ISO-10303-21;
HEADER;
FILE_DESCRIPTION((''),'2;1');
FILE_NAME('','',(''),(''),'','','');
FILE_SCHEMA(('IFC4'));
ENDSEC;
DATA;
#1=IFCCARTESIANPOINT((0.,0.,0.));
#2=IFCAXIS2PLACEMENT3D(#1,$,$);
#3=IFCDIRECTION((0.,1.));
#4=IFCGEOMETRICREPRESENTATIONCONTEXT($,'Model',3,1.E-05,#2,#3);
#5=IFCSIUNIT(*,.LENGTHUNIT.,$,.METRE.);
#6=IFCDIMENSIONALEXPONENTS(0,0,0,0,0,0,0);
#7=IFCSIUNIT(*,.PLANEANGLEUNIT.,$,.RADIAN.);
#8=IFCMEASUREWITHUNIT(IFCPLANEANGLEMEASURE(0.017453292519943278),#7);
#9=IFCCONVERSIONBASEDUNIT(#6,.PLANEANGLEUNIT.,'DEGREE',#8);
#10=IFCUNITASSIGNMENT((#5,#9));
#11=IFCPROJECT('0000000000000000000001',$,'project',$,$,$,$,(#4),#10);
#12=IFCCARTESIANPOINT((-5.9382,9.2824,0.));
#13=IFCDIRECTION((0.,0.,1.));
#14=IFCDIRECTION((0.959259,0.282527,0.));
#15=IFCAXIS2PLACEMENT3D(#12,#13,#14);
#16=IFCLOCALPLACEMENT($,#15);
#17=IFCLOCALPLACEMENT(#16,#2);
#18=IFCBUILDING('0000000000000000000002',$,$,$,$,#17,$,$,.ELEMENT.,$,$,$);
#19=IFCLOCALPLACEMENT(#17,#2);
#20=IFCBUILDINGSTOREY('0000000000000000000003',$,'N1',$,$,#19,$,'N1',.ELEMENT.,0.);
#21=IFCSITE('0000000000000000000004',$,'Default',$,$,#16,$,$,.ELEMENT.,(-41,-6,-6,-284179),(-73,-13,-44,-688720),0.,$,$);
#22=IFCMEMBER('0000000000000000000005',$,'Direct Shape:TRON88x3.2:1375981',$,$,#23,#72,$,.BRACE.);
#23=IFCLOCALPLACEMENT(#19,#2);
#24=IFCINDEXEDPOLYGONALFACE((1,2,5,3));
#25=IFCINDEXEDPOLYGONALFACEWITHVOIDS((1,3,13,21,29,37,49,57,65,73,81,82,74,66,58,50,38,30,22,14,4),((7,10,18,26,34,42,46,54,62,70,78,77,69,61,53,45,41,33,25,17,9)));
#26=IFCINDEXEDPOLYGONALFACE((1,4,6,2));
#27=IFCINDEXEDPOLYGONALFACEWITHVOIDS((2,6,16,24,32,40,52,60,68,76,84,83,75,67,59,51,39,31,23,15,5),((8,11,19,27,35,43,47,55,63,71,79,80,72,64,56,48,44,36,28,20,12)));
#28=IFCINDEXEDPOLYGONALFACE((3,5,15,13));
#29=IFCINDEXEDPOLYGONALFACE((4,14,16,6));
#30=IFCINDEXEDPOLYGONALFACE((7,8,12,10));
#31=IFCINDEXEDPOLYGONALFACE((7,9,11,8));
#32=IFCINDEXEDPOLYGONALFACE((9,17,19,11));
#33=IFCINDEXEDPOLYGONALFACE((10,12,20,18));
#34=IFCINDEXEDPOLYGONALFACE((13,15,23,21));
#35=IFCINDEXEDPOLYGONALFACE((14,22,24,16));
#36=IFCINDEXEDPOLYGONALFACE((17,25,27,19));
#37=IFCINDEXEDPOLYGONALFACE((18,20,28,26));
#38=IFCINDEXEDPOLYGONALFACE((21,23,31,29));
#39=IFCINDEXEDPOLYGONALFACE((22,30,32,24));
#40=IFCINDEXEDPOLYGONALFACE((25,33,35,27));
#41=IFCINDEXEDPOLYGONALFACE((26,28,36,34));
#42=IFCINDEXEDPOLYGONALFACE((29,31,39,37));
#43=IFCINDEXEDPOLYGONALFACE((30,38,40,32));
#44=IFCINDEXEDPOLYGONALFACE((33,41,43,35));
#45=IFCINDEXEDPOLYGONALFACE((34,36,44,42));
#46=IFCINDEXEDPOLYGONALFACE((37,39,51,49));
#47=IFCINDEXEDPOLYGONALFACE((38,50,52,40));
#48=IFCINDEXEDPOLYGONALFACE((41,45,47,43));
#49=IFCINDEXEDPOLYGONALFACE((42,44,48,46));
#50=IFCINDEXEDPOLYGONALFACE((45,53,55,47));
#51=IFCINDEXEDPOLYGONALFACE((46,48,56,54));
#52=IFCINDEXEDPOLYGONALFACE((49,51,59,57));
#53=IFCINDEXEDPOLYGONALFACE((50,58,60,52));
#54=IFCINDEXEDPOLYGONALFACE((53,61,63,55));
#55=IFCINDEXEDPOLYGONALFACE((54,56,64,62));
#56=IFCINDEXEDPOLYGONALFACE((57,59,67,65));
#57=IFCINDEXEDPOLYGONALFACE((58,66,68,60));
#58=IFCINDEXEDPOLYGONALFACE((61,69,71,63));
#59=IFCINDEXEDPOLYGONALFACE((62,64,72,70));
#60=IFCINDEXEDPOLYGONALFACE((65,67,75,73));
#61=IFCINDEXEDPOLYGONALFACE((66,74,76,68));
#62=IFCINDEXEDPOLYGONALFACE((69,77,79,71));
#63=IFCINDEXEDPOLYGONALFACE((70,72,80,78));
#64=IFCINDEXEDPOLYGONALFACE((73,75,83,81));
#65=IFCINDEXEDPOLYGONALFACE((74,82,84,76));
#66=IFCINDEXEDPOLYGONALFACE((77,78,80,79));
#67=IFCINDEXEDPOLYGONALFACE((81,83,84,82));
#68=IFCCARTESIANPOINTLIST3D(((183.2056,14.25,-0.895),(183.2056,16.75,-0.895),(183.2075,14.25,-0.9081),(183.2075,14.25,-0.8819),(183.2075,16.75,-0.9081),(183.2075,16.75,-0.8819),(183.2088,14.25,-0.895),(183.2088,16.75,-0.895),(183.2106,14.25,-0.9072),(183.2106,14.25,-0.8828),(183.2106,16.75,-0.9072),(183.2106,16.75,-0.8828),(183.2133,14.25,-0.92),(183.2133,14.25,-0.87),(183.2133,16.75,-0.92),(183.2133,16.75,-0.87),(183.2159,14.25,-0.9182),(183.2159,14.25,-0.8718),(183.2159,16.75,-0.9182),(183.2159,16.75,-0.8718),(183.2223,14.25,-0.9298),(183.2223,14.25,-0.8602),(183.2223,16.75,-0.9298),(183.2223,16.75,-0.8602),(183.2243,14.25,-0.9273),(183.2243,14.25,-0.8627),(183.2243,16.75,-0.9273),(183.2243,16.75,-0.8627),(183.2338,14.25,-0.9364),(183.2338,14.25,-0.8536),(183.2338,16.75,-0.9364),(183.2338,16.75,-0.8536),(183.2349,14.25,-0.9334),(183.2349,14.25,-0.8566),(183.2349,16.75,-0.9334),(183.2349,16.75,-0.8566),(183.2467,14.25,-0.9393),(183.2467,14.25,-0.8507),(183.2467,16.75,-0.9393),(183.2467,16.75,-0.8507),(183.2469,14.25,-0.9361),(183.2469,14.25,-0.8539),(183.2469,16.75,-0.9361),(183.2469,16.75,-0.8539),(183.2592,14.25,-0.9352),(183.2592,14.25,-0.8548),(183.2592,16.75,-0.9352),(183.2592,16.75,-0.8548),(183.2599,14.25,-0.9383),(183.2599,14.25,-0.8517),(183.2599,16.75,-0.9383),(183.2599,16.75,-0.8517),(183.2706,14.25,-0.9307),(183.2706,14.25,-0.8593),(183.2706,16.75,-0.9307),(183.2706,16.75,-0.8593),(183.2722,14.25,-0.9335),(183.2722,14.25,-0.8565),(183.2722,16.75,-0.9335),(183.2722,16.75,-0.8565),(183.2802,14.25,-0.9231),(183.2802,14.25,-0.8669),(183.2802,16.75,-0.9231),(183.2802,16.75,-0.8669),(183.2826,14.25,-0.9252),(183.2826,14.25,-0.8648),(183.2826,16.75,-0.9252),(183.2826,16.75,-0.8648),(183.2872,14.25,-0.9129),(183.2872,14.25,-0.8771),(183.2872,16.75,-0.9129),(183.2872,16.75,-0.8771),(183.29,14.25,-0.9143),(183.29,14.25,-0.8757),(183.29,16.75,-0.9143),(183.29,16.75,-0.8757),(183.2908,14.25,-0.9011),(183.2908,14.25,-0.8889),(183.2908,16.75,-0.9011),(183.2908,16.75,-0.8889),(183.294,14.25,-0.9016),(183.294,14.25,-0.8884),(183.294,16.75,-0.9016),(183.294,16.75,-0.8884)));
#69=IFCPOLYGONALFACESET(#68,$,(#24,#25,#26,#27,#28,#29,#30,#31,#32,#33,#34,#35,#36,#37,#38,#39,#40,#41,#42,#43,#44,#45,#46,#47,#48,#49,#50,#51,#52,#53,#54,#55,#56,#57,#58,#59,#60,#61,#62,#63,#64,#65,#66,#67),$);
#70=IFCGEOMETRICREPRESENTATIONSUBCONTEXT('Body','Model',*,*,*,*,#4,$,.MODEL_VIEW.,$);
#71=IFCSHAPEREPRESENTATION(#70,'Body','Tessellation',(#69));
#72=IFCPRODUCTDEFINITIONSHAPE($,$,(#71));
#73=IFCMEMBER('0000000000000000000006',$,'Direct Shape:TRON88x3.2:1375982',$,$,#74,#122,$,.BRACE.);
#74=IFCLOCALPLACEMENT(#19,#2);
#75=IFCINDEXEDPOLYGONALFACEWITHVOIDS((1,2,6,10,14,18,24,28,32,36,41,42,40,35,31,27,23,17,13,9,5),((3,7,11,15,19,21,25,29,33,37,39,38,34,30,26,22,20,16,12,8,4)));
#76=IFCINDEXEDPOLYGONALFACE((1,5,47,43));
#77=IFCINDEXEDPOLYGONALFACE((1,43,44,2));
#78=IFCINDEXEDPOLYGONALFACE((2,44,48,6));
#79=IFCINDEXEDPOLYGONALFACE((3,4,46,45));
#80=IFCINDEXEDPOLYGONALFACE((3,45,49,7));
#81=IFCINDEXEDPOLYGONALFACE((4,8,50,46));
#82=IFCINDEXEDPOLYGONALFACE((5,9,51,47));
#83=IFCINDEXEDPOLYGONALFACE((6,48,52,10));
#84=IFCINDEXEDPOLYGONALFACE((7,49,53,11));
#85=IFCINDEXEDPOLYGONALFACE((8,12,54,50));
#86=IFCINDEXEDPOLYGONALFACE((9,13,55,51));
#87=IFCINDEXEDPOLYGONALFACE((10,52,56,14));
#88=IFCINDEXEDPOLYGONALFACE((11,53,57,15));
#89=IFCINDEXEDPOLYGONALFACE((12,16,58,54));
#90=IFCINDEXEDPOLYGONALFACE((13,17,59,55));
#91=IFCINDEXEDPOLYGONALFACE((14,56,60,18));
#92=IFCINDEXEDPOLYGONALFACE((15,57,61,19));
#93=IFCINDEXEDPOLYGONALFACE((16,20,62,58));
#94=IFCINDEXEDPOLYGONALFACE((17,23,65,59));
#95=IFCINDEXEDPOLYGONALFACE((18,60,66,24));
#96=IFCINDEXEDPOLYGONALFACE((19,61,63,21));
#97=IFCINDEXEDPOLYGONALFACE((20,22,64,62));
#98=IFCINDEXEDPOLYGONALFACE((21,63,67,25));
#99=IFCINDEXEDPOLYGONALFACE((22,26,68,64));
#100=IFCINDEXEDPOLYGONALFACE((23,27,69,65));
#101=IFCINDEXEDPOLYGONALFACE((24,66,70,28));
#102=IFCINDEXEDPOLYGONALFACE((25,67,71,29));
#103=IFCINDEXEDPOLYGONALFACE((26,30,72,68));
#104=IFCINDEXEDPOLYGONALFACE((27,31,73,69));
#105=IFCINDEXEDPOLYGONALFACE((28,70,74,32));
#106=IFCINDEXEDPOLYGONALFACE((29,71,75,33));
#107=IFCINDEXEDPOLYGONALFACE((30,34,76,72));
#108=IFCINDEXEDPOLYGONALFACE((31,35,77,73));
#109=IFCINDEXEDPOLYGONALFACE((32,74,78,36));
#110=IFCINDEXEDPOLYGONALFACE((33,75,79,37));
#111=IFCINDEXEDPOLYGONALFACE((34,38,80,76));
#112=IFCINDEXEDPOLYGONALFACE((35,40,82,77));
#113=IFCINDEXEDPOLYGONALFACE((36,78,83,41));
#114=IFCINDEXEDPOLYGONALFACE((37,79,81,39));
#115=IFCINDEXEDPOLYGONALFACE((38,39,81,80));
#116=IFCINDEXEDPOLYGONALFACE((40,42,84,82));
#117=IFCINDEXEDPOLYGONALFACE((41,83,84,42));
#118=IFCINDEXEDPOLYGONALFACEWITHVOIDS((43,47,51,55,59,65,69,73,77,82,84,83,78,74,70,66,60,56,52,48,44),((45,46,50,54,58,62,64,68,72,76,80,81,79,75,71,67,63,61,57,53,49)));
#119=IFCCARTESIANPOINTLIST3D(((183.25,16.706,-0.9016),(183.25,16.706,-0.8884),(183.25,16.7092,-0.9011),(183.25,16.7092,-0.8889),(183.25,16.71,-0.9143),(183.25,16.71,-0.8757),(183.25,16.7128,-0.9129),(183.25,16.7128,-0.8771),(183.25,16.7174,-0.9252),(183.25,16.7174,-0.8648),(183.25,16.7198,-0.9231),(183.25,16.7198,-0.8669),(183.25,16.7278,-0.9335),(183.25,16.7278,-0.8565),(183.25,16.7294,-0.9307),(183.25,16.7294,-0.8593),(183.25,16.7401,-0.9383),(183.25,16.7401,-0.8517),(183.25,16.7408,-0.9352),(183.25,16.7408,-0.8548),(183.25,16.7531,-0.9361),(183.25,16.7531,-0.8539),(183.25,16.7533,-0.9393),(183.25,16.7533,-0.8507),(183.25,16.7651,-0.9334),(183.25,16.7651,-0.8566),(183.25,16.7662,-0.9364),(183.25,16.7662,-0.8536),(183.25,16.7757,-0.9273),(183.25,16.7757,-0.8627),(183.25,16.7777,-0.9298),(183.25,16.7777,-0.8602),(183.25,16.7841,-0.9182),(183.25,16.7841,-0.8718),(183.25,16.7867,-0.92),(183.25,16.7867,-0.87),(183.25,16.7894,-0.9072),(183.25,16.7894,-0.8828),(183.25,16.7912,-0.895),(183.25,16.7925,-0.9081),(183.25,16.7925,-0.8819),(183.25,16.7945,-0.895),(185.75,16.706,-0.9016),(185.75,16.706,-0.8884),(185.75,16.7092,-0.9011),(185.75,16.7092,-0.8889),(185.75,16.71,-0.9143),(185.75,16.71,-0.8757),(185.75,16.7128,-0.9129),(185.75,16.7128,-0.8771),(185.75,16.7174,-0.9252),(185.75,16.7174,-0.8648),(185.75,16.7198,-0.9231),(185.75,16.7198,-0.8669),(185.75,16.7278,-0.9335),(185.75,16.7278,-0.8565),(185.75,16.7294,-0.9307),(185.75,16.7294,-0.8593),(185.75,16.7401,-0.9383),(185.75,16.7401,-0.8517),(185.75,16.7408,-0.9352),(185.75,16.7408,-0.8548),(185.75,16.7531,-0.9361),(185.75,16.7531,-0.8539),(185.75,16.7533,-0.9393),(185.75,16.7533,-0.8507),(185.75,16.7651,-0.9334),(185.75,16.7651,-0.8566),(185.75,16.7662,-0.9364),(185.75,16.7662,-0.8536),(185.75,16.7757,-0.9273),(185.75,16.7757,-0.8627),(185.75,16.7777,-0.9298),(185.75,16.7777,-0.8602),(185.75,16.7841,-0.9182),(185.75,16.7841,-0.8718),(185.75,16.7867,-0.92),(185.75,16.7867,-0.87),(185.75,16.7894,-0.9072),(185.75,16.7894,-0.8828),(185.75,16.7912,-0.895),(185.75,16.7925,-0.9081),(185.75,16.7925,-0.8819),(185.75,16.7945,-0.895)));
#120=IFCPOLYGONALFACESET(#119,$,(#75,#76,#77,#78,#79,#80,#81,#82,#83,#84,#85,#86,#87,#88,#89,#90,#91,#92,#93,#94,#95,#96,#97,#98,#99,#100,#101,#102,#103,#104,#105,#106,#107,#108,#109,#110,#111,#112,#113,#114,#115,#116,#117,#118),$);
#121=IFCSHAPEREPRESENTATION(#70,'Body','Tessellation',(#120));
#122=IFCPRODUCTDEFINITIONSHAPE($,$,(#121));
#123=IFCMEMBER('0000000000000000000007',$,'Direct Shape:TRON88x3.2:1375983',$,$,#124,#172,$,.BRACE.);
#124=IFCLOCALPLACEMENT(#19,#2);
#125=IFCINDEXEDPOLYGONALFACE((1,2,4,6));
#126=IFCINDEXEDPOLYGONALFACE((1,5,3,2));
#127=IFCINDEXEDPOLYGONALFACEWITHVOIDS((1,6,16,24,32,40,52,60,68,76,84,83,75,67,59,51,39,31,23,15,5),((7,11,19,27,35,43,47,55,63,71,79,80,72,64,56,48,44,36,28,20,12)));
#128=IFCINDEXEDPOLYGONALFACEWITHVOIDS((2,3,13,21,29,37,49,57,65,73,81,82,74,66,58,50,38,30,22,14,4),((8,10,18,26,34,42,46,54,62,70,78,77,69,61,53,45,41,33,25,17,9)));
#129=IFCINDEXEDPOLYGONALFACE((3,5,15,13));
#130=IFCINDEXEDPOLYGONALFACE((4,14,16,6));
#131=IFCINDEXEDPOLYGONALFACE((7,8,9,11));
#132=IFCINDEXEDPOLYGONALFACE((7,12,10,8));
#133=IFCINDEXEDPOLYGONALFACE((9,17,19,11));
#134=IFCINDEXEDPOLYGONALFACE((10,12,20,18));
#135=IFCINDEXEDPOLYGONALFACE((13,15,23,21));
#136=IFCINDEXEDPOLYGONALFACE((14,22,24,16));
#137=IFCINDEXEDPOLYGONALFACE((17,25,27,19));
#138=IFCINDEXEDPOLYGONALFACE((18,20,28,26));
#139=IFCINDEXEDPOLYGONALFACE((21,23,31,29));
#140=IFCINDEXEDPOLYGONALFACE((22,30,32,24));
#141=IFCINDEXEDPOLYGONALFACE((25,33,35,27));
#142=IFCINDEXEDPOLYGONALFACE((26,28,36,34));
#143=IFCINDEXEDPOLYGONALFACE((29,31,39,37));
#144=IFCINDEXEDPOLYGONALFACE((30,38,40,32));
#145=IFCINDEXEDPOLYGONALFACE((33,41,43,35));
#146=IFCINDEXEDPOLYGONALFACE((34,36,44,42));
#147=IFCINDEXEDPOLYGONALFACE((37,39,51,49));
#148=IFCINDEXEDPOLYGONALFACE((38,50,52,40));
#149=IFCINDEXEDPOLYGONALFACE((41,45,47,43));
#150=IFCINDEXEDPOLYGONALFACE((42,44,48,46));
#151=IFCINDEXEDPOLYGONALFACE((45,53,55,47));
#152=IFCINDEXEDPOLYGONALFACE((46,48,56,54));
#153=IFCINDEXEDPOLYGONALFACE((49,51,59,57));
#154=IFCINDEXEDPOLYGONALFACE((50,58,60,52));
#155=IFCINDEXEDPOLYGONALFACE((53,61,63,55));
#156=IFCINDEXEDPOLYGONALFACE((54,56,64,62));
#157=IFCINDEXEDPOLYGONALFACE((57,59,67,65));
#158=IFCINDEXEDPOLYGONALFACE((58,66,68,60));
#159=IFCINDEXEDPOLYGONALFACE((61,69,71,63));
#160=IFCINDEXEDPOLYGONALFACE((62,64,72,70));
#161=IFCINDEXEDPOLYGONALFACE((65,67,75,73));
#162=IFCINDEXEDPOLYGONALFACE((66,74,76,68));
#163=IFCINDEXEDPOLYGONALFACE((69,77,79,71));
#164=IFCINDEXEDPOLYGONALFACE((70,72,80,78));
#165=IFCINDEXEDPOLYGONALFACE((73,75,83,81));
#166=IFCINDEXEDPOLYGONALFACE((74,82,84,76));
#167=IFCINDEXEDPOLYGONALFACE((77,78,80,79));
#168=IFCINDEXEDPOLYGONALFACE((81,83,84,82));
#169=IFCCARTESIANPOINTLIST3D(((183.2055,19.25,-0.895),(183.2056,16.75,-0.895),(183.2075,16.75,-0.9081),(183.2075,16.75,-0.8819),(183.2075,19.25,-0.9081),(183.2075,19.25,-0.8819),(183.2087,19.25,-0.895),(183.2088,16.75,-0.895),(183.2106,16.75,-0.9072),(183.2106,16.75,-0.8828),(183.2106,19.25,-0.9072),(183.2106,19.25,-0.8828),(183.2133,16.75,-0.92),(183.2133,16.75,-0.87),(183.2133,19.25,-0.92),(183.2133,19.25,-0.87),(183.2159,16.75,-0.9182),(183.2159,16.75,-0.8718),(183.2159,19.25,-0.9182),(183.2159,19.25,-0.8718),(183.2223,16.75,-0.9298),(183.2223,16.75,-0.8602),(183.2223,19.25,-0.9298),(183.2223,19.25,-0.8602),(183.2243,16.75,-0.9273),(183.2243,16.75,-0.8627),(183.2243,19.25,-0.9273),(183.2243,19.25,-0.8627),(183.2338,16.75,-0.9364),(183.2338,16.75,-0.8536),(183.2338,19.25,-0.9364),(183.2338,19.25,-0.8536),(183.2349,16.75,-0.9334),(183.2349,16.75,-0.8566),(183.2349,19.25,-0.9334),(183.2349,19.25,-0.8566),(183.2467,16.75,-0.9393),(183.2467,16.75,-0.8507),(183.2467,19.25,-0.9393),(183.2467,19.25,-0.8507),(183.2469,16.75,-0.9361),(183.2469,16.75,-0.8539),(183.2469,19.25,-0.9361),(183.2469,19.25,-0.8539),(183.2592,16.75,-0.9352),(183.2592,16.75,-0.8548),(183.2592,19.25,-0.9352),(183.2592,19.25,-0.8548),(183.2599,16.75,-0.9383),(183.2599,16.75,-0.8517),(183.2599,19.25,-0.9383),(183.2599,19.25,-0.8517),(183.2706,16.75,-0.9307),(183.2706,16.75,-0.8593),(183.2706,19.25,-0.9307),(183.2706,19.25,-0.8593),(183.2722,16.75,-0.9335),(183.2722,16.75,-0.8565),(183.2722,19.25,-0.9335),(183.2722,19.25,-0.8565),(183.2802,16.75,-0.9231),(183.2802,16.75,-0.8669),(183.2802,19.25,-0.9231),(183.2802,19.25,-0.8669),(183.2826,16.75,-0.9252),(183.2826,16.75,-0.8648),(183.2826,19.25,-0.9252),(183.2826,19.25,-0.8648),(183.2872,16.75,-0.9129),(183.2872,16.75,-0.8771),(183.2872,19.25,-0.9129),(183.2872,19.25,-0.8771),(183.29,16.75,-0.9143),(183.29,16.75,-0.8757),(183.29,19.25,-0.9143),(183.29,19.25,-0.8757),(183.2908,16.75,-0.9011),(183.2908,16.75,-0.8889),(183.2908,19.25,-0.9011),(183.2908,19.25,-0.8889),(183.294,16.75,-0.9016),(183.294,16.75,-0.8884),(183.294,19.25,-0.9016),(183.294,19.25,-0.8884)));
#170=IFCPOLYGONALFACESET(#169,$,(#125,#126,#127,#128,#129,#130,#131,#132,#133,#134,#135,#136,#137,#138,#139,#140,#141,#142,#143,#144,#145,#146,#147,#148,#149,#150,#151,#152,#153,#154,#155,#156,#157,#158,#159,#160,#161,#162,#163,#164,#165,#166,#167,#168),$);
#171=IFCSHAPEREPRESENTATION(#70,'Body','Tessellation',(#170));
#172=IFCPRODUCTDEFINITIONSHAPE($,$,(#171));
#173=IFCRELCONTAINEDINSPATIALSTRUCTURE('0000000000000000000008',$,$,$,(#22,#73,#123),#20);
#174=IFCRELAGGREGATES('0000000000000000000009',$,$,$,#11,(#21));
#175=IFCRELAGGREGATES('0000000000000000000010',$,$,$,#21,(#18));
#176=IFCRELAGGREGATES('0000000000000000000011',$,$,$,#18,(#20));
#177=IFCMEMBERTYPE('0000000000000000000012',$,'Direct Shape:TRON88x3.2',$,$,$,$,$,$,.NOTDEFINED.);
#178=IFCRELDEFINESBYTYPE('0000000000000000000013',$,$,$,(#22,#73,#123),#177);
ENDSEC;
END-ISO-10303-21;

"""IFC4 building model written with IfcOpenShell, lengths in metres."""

from ifc_helpers import new_model, entity, si_unit, converted_unit, direction, frame, frame_2d, origin, place, context, subcontext, project, spatial, hollow_circle, extrude, type_object, element, save


model = new_model("IFC4")

# Units and contexts
model_context = context("Model", 3, precision=1e-05, world=origin(), true_north=direction((0.0, 1.0)))
body_context = subcontext(model_context, "Body", "Model", "MODEL_VIEW")
ifc_project = project(units=[si_unit("LENGTHUNIT", "METRE"), converted_unit("PLANEANGLEUNIT", "DEGREE", entity("IfcPlaneAngleMeasure", 0.017453292519943278), si_unit("PLANEANGLEUNIT", "RADIAN"), dimensions=[0, 0, 0, 0, 0, 0, 0])], contexts=[model_context])

# Site, building, storey
site_placement = place(None, frame((-5.9382, 9.2824, 0.0), z_axis=(0.0, 0.0, 1.0), x_axis=(0.959259, 0.282527, 0.0)))
site = spatial("IfcSite", under=ifc_project, at=site_placement, Name="Default", CompositionType="ELEMENT", RefLatitude=(-41, -6, -6, -284179), RefLongitude=(-73, -13, -44, -688720), RefElevation=0.0)
building_placement = place(site_placement, origin())
building = spatial("IfcBuilding", under=site, at=building_placement, CompositionType="ELEMENT")
storey_placement = place(building_placement, origin())
storey = spatial("IfcBuildingStorey", under=building, at=storey_placement, Name="N1", LongName="N1", CompositionType="ELEMENT", Elevation=0.0)

# Members
member_type_1 = type_object("IfcMemberType", Name="Direct Shape:TRON88x3.2", PredefinedType="NOTDEFINED")
member_1_placement = place(storey_placement, origin())
element("IfcMember", 1, at=member_1_placement, inside=storey, type_object=member_type_1, Name="Direct Shape:TRON88x3.2:1375981", PredefinedType="BRACE", context=body_context, shape_type="SweptSolid", body=[
    extrude(hollow_circle(Radius=0.0445, WallThickness=0.0032, at=frame_2d((0.0, 0.0), x_axis=(1.0, 0.0))), frame((183.25, 14.25, -0.895), z_axis=(0.0, 1.0, 0.0), x_axis=(-1.0, 0.0, 0.0)), (0.0, 0.0, 1.0), 2.5),
])
member_2_placement = place(storey_placement, origin())
element("IfcMember", 2, at=member_2_placement, inside=storey, type_object=member_type_1, Name="Direct Shape:TRON88x3.2:1375982", PredefinedType="BRACE", context=body_context, shape_type="SweptSolid", body=[
    extrude(hollow_circle(Radius=0.0445, WallThickness=0.0032, at=frame_2d((0.0, 0.0), x_axis=(1.0, 0.0))), frame((183.25, 16.75, -0.895), z_axis=(1.0, 0.0, 0.0), x_axis=(0.0, 1.0, 0.0)), (0.0, 0.0, 1.0), 2.5),
])
member_3_placement = place(storey_placement, origin())
element("IfcMember", 3, at=member_3_placement, inside=storey, type_object=member_type_1, Name="Direct Shape:TRON88x3.2:1375983", PredefinedType="BRACE", context=body_context, shape_type="SweptSolid", body=[
    extrude(hollow_circle(Radius=0.0445, WallThickness=0.0032, at=frame_2d((0.0, 0.0), x_axis=(1.0, 0.0))), frame((183.25, 16.75, -0.895), z_axis=(0.0, 1.0, 0.0), x_axis=(-1.0, 0.0, 0.0)), (0.0, 0.0, 1.0), 2.5),
])

save(model, "model.ifc")
